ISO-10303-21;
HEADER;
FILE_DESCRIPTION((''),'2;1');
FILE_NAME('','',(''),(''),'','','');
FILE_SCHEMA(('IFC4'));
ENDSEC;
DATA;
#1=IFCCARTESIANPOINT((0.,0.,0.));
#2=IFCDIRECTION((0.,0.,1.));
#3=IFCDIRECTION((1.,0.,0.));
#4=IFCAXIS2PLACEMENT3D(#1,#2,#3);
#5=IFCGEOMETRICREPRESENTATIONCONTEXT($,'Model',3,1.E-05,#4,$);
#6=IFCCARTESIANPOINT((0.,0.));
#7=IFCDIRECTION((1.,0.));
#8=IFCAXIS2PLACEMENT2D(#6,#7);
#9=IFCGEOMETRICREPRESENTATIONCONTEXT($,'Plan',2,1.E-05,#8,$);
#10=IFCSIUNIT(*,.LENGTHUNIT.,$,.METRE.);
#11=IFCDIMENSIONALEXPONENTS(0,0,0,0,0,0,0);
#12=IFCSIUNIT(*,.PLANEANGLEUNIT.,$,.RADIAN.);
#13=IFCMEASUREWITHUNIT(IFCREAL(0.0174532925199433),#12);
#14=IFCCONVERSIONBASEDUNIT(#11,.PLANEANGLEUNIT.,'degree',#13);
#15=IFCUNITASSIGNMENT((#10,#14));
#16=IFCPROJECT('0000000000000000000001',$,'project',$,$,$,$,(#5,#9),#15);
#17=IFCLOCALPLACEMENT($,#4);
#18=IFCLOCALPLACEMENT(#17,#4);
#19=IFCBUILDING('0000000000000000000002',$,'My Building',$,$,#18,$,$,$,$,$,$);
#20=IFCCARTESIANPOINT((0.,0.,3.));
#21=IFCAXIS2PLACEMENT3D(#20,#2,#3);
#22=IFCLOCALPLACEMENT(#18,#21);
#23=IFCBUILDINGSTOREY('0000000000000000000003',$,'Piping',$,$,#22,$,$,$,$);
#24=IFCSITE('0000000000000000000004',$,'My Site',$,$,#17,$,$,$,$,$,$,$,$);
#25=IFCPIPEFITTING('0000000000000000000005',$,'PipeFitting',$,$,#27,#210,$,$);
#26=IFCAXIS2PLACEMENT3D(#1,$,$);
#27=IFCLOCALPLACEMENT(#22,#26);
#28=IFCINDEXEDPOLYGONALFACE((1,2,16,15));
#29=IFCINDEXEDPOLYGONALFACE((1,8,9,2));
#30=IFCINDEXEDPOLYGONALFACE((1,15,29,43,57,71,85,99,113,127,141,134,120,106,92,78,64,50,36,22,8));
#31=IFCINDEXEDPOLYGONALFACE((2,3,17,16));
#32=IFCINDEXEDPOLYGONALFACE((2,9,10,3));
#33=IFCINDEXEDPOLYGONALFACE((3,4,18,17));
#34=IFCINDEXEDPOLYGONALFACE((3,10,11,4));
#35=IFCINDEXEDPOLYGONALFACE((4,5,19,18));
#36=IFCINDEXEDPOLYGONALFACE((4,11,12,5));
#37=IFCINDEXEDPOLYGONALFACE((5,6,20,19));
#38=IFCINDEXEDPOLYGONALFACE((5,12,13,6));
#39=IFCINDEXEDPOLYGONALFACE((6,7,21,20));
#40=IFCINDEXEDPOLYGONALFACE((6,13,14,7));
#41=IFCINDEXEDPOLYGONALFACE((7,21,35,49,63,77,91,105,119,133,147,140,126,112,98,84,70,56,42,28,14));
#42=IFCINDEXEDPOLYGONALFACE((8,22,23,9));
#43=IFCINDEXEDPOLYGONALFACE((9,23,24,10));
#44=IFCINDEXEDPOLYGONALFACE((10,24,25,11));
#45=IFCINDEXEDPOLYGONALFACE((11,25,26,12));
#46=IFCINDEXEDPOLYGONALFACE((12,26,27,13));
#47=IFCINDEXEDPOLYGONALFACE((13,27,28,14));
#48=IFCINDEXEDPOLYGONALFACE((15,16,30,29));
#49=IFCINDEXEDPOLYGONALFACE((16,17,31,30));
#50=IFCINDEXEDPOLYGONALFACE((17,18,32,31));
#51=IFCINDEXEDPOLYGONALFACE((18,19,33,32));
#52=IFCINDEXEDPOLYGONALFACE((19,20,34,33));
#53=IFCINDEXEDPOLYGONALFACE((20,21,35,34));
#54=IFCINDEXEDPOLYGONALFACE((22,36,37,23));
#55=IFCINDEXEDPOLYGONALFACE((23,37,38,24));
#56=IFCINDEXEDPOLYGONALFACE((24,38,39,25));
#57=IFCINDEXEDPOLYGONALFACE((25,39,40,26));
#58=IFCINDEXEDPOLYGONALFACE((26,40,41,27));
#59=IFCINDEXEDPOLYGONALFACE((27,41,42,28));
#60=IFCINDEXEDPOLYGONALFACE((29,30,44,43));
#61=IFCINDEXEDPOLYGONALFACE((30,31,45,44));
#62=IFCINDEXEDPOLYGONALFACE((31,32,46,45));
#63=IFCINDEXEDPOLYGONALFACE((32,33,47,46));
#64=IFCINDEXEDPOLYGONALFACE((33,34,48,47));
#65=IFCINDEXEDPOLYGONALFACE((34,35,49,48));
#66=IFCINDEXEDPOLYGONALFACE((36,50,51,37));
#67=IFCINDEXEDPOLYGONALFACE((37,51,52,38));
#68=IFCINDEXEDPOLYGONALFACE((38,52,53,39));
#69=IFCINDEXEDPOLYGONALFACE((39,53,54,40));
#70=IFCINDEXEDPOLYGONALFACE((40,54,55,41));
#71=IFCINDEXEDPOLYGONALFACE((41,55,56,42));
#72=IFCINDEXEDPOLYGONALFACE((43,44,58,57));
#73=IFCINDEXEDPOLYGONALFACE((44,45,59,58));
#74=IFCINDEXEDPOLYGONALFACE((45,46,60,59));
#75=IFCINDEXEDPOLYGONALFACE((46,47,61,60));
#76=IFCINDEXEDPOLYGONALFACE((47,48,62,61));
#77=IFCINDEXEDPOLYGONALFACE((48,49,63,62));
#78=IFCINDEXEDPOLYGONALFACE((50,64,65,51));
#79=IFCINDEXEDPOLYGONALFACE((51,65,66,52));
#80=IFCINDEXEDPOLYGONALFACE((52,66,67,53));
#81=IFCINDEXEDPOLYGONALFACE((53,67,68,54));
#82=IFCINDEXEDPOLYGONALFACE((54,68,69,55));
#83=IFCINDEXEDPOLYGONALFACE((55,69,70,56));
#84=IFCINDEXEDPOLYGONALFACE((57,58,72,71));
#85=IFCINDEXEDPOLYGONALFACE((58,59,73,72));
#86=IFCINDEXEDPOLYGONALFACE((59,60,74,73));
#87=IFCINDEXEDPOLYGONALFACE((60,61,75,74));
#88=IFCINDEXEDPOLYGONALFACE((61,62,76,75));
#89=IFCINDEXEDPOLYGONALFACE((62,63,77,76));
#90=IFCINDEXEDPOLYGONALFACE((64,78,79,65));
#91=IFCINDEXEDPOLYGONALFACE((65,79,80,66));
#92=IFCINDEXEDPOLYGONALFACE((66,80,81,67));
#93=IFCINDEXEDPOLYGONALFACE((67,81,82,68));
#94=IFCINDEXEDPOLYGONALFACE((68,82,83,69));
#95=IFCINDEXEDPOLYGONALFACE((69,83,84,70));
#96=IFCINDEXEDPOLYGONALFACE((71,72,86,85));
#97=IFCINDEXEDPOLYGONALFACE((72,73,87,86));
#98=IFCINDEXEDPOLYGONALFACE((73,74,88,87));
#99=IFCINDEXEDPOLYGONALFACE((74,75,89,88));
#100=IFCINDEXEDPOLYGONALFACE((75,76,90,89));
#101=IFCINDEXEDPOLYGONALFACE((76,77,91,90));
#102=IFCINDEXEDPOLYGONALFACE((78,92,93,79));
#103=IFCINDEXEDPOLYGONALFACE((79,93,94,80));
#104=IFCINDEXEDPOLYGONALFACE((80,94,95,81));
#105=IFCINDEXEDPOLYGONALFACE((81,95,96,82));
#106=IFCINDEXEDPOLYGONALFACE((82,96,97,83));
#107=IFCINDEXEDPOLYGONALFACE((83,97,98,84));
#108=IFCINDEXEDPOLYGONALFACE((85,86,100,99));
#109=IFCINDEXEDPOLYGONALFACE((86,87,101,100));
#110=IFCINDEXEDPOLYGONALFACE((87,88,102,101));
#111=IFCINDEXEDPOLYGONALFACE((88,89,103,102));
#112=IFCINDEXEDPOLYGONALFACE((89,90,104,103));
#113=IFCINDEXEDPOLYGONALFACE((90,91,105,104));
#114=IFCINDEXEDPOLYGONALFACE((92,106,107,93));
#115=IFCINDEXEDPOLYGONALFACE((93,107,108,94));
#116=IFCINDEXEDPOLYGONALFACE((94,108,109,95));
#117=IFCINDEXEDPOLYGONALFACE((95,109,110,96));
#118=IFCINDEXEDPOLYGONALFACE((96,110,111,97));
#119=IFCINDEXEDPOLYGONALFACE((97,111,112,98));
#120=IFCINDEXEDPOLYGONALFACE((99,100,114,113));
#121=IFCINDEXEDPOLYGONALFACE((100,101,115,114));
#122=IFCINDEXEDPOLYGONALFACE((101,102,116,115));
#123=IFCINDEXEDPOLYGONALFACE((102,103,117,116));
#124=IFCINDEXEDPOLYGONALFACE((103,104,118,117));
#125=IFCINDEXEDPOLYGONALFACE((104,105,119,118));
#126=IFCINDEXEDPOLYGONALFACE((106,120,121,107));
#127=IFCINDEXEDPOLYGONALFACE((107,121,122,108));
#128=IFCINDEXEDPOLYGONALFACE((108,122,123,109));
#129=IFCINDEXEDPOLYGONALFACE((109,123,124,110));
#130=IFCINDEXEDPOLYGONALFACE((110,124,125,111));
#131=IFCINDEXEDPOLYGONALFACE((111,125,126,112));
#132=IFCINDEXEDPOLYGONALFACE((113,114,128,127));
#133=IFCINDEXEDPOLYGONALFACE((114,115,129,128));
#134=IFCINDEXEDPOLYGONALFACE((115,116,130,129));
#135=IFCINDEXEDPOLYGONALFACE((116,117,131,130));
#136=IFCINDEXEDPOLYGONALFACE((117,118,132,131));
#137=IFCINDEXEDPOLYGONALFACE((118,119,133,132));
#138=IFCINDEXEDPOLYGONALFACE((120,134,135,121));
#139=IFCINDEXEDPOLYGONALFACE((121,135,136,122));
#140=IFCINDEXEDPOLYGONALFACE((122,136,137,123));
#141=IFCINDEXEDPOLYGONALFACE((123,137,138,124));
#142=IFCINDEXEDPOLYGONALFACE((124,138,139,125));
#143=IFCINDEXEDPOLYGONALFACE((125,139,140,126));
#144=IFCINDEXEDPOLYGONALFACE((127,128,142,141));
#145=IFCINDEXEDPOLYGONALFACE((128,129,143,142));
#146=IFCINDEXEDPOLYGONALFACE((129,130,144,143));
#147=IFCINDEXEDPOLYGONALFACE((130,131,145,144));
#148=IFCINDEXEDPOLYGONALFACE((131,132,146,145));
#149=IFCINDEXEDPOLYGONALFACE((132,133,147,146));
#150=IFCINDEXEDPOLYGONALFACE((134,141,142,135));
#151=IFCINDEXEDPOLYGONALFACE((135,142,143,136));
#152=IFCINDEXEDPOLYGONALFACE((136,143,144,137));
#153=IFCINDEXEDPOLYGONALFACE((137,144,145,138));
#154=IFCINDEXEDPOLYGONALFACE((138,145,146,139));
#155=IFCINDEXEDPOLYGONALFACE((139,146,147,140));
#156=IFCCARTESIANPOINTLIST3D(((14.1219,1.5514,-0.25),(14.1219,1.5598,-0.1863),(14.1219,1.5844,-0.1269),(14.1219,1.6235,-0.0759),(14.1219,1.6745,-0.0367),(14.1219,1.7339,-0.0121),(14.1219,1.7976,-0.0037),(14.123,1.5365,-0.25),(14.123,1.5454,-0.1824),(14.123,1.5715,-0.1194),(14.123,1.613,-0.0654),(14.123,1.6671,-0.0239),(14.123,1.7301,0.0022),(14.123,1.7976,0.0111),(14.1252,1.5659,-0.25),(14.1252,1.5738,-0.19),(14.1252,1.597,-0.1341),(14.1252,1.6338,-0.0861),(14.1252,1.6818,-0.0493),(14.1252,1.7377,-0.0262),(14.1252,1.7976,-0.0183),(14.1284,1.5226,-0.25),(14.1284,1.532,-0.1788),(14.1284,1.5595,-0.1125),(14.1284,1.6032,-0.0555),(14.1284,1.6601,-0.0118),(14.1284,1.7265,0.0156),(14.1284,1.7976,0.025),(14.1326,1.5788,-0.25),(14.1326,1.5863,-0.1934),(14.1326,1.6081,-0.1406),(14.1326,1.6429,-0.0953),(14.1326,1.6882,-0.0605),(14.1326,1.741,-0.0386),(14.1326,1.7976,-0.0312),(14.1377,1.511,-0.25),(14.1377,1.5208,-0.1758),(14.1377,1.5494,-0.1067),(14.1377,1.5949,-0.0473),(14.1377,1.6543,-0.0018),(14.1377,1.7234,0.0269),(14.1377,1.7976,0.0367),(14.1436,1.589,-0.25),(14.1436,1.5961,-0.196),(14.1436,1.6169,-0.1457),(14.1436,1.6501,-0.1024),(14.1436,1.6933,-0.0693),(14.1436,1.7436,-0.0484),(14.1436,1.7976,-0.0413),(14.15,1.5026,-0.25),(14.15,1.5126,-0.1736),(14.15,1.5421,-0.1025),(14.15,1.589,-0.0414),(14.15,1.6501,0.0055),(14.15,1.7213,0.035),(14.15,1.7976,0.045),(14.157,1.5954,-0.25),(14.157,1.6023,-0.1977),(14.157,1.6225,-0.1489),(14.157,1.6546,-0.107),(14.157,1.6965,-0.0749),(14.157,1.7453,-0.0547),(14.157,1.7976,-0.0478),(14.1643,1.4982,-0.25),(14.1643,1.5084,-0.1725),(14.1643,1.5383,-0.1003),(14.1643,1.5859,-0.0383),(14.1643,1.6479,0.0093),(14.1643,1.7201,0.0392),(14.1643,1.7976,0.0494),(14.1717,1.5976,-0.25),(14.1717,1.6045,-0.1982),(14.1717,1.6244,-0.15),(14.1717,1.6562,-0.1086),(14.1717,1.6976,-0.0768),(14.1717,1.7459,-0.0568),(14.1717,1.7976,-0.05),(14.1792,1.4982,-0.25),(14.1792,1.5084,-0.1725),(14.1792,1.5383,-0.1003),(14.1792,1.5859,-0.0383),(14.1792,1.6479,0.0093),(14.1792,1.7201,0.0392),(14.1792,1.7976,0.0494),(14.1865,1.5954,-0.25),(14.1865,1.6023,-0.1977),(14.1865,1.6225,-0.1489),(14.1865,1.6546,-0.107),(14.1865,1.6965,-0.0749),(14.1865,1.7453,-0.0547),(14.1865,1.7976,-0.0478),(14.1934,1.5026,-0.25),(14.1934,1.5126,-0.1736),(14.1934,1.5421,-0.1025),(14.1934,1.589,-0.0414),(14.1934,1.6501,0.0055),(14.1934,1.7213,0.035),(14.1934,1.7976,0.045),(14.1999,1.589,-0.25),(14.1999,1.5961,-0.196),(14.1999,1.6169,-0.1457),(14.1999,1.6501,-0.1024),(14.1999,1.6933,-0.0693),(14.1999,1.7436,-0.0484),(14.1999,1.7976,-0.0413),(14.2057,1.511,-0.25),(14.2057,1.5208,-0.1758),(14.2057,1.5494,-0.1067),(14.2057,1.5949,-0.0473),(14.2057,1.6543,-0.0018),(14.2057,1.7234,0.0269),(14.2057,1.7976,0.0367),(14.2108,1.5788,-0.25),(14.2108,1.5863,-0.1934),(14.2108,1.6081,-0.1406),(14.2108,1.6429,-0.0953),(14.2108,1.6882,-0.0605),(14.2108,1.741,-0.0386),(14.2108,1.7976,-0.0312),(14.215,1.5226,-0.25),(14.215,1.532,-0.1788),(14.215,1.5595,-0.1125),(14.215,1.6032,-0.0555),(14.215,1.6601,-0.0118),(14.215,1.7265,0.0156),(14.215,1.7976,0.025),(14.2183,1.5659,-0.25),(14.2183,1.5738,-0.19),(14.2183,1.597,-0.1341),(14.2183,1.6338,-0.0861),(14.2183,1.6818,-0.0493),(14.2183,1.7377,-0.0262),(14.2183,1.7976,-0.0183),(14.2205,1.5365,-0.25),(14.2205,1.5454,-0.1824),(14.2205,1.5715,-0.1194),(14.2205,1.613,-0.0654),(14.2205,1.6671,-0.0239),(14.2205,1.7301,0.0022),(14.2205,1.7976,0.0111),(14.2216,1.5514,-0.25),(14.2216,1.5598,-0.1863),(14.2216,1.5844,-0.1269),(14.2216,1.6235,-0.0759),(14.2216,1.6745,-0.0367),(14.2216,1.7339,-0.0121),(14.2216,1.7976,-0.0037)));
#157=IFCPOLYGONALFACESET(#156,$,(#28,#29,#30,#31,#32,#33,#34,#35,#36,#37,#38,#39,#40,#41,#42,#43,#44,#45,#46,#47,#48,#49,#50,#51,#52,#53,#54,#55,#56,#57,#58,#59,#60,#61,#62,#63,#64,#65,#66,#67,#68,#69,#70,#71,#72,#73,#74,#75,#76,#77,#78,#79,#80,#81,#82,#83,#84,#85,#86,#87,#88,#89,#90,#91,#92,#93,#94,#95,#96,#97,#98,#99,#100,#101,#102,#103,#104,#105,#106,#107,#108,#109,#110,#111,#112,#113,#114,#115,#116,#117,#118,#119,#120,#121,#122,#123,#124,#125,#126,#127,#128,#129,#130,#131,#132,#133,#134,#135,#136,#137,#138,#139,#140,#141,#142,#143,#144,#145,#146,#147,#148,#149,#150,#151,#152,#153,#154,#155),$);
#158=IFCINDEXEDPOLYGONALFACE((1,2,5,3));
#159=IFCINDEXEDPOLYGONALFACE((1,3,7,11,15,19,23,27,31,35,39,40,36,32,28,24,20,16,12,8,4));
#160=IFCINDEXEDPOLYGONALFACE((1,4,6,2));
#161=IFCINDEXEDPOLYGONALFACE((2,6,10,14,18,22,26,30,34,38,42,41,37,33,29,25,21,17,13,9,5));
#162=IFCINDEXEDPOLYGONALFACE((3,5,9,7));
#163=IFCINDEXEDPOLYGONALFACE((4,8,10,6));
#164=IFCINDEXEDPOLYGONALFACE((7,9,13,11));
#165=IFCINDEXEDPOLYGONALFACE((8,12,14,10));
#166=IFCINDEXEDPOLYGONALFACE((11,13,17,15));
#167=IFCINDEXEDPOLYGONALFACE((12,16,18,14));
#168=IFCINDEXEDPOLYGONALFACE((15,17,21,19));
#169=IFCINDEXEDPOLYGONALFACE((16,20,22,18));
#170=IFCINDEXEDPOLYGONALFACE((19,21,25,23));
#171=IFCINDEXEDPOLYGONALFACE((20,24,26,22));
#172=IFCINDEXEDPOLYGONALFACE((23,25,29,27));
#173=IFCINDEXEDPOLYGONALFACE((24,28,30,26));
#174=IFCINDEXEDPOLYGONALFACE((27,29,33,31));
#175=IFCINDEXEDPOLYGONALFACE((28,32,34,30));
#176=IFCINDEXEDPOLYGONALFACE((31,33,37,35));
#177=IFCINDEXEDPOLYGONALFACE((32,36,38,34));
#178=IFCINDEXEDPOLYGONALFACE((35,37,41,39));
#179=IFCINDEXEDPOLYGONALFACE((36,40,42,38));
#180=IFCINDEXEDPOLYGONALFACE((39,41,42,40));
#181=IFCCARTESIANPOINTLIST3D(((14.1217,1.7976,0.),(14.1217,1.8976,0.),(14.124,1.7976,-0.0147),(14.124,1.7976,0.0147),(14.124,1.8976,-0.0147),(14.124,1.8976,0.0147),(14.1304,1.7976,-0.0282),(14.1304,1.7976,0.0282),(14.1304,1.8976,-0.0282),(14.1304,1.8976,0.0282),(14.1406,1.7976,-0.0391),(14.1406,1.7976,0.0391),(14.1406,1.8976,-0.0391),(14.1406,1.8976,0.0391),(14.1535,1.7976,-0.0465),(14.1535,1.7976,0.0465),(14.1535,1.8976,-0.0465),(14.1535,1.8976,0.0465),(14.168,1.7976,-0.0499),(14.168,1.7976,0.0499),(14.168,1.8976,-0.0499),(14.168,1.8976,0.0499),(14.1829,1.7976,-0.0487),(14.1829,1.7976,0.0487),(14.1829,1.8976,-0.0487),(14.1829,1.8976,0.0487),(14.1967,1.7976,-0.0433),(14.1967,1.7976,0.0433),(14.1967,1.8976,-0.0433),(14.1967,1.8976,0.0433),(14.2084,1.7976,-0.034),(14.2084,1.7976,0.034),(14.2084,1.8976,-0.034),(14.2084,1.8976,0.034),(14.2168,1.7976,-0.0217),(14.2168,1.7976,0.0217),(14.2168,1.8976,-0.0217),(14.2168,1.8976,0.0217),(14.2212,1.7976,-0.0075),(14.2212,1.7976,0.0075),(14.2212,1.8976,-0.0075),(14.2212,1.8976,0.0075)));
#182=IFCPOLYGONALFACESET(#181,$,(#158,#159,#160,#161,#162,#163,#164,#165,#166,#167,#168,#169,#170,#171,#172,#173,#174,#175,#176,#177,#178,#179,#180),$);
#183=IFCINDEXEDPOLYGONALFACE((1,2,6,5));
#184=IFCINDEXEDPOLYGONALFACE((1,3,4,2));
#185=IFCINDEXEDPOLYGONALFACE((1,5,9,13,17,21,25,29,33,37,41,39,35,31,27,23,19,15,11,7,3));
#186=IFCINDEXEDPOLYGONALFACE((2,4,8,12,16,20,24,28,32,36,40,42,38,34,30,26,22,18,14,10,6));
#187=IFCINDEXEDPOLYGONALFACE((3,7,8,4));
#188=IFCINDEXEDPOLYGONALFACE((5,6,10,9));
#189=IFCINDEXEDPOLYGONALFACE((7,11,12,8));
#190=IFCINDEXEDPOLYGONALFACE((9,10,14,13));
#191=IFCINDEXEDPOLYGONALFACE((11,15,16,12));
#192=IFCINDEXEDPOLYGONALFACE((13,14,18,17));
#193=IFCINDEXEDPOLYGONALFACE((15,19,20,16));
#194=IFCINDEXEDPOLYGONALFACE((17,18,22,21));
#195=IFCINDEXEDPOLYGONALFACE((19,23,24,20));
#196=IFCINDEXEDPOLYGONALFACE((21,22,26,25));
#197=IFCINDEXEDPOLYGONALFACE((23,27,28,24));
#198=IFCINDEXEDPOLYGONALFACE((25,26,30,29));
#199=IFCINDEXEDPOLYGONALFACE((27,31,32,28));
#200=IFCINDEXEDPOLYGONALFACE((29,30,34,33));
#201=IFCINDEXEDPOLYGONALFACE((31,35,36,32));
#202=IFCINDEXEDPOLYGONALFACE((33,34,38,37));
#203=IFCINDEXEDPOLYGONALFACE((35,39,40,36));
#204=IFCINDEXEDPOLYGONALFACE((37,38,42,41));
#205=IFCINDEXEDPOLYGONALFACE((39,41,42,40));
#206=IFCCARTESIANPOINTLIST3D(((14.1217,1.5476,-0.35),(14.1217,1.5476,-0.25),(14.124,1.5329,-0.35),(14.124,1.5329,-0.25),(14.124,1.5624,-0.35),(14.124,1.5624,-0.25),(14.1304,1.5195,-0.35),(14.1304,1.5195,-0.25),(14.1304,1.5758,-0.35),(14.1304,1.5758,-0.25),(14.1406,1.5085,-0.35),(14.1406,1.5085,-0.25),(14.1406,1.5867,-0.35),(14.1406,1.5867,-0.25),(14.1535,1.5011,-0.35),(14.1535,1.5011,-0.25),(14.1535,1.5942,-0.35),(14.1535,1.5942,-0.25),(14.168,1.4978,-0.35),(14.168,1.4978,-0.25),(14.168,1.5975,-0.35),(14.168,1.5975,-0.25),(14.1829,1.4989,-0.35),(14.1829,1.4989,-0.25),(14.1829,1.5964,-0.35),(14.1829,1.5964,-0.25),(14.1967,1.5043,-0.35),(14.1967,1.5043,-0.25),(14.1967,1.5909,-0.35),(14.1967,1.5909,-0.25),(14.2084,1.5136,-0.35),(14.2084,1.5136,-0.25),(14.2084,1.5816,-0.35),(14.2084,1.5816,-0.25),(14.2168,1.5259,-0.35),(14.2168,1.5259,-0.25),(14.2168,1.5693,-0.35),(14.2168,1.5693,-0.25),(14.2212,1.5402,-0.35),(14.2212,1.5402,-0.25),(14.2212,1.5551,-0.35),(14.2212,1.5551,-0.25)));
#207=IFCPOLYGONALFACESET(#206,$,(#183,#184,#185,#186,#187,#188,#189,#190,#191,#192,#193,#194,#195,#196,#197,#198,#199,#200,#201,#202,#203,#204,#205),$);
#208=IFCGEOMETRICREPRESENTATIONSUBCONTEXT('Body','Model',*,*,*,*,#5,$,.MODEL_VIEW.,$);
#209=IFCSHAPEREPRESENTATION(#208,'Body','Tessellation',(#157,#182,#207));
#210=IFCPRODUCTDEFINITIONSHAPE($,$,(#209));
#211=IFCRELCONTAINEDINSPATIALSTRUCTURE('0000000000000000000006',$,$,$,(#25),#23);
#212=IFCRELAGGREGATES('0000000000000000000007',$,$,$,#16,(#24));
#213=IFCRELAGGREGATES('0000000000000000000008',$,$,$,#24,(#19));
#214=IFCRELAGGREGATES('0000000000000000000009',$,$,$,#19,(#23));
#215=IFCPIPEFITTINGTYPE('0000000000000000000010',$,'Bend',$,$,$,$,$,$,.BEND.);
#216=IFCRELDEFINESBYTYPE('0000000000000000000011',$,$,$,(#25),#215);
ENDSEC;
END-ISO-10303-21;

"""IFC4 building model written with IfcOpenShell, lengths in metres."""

from ifc_helpers import new_model, entity, si_unit, converted_unit, frame, origin_with_axes, origin_2d_with_axis, place, context, subcontext, project, spatial, circle, extrude, source, transform, mapped, type_object, type_shapes, element, save


model = new_model("IFC4")

# Units and contexts
model_context = context("Model", 3, precision=1e-05, world=origin_with_axes())
plan_context = context("Plan", 2, precision=1e-05, world=origin_2d_with_axis())
body_context = subcontext(model_context, "Body", "Model", "MODEL_VIEW")
ifc_project = project(units=[si_unit("LENGTHUNIT", "METRE"), converted_unit("PLANEANGLEUNIT", "degree", entity("IfcReal", 0.0174532925199433), si_unit("PLANEANGLEUNIT", "RADIAN"), dimensions=[0, 0, 0, 0, 0, 0, 0])], contexts=[model_context, plan_context])

# Site, building, storey
site_placement = place(None, origin_with_axes())
site = spatial("IfcSite", under=ifc_project, at=site_placement, Name="My Site")
building_placement = place(site_placement, origin_with_axes())
building = spatial("IfcBuilding", under=site, at=building_placement, Name="My Building")
storey_placement = place(building_placement, frame((0.0, 0.0, 3.0), z_axis=(0.0, 0.0, 1.0), x_axis=(1.0, 0.0, 0.0)))
storey = spatial("IfcBuildingStorey", under=building, at=storey_placement, Name="Piping")

# Pipe fitting
pipe_fitting_type_1 = type_object("IfcPipeFittingType", Name="Bend", PredefinedType="BEND")
shared_shape = source(origin_with_axes(), body_context, "Body", "SolidModel", [
    entity("IfcSweptDiskSolid", entity("IfcIndexedPolyCurve", entity("IfcCartesianPointList3D", [[0.0, 0.0, -0.1], [0.0, -0.0732, -0.2768], [0.0, -0.25, -0.35]]), [entity("IfcArcIndex", [1, 2, 3])]), 0.05),
    extrude(circle(Radius=0.05), origin_with_axes(), (0.0, 0.0, -1.0), 0.1),
    extrude(circle(Radius=0.05), frame((0.0, -0.25, -0.35), z_axis=(0.0, -1.0, 0.0), x_axis=(1.0, 0.0, 0.0)), (0.0, 0.0, 1.0), 0.1),
])
type_shapes(pipe_fitting_type_1, [shared_shape])
for number, where, z_axis, x_axis, name in (
    (1, (14.1717, 1.8976, 0.0), (0.0, 1.0, 0.0), (-1.0, 0.0, 0.0), "PipeFitting"),
):
    element("IfcPipeFitting", number, at=place(storey_placement, frame(where, z_axis=z_axis, x_axis=x_axis)), inside=storey, type_object=pipe_fitting_type_1, Name=name, context=body_context, shape_type="MappedRepresentation", body=[
        mapped(shared_shape, transform((0.0, 0.0, 0.0), x_axis=(1.0, 0.0, 0.0), y_axis=(0.0, 1.0, 0.0), z_axis=(0.0, 0.0, 1.0), scale=1.0)),
    ])

save(model, "model.ifc")
